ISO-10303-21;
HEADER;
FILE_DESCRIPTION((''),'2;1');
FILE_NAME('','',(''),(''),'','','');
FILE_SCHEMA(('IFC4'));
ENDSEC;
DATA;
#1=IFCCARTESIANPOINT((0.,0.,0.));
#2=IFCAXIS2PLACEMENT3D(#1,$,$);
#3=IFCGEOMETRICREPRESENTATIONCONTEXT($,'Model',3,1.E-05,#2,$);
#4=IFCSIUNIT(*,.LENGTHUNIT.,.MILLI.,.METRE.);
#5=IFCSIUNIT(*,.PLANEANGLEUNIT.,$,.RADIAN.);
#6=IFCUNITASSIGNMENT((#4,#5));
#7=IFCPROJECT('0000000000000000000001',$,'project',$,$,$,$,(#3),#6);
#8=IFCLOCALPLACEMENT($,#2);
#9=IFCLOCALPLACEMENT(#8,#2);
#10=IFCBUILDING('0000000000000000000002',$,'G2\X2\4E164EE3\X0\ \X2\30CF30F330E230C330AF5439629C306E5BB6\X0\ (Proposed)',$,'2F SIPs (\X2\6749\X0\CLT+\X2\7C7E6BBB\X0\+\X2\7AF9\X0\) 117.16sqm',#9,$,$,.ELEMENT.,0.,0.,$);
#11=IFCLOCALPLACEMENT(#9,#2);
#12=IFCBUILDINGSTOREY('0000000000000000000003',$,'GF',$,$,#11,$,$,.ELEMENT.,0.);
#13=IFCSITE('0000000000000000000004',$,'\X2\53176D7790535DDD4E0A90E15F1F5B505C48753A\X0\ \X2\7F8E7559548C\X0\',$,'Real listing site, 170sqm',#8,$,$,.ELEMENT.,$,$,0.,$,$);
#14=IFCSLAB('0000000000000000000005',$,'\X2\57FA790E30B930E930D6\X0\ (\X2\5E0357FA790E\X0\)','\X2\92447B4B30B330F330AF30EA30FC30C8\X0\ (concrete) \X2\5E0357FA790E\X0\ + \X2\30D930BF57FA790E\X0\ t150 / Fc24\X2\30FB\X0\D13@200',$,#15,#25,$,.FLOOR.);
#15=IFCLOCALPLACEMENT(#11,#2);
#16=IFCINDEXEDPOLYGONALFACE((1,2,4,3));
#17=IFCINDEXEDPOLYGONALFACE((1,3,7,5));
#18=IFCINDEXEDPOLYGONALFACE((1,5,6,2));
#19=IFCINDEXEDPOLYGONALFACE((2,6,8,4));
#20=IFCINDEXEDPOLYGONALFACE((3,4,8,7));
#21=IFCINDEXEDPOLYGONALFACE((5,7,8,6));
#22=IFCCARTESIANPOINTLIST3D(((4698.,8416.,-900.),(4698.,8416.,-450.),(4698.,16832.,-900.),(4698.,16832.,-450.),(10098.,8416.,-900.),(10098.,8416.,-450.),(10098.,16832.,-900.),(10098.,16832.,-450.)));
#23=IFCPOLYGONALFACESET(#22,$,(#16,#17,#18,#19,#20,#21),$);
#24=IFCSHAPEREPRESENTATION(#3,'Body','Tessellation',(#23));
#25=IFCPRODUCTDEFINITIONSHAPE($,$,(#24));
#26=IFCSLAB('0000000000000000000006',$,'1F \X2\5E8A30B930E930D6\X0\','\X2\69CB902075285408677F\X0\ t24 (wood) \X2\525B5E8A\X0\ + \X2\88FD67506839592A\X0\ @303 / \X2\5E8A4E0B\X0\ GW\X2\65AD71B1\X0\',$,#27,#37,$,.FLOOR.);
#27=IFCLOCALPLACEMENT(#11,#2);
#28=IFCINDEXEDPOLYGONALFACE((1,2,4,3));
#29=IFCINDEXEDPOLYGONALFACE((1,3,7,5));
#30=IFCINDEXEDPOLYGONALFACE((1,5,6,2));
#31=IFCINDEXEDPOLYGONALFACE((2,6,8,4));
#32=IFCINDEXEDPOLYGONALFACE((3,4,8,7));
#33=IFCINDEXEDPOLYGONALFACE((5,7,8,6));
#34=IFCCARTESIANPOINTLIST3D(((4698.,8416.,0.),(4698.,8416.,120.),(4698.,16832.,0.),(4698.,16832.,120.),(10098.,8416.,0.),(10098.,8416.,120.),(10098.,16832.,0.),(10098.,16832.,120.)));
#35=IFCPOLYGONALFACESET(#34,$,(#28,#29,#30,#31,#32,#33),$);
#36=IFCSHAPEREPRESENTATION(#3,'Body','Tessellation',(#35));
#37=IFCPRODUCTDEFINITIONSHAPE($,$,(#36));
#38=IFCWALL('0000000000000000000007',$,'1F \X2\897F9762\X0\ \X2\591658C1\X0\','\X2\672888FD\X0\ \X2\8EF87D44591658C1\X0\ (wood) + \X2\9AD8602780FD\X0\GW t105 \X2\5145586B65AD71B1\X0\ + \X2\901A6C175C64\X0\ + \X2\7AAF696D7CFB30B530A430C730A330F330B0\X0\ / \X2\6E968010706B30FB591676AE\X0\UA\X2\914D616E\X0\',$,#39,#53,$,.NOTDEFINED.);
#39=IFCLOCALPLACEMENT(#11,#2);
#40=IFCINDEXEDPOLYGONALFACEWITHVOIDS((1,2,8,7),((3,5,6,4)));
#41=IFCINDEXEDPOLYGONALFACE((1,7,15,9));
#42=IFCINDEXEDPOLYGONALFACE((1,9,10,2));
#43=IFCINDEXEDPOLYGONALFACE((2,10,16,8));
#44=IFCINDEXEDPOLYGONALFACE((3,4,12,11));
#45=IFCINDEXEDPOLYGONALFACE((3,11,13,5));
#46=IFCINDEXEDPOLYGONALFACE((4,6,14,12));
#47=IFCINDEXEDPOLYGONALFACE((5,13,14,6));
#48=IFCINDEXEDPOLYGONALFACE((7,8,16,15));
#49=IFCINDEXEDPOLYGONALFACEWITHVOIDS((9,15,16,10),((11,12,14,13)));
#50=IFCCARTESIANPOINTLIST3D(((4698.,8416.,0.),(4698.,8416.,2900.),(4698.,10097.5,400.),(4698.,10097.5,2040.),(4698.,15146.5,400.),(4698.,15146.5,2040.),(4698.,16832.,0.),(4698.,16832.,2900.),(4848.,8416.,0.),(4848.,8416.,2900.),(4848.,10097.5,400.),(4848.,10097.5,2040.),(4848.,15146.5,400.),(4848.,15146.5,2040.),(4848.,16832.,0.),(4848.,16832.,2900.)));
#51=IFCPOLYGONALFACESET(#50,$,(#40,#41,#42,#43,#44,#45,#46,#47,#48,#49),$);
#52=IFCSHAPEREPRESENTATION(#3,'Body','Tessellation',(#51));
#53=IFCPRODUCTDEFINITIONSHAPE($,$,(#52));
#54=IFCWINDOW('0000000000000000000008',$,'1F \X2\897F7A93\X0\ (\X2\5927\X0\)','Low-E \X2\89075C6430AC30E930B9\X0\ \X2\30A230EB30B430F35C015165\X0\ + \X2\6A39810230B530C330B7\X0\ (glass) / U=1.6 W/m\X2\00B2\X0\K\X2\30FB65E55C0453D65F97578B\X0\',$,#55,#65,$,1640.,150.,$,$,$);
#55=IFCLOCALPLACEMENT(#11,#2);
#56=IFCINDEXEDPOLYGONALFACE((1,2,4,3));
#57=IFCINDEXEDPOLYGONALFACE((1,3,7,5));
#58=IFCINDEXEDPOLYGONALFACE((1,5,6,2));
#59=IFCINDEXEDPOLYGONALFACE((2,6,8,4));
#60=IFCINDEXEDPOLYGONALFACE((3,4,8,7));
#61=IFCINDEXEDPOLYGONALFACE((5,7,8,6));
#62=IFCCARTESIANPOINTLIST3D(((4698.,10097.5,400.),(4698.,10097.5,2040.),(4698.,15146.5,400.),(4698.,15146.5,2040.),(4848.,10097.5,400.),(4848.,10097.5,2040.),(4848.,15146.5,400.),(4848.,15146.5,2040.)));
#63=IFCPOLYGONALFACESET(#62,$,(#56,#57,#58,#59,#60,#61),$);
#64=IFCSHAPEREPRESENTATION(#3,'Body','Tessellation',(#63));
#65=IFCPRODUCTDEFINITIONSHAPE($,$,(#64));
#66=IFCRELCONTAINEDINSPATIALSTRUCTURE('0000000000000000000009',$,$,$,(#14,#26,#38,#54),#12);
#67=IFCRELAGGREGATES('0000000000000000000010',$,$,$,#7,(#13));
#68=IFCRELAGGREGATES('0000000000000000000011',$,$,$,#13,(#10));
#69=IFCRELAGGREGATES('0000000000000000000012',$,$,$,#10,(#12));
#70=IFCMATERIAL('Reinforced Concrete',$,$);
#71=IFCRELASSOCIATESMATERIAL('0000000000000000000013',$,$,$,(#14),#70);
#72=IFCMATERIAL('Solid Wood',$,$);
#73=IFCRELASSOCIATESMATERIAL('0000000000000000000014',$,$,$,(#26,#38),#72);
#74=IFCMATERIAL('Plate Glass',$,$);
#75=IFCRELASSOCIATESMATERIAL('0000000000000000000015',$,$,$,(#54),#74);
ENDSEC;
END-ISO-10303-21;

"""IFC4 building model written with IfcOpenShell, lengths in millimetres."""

from ifc_helpers import new_model, si_unit, frame, frame_2d, origin, place, context, project, spatial, rectangle, extrude, material, element, fill, save


model = new_model("IFC4")

# Units and contexts
model_context = context("Model", 3, precision=1e-05, world=origin())
ifc_project = project(units=[si_unit("LENGTHUNIT", "METRE", prefix="MILLI"), si_unit("PLANEANGLEUNIT", "RADIAN")], contexts=[model_context])

# Site, building, storey
site_placement = place(None, origin())
site = spatial("IfcSite", under=ifc_project, at=site_placement, Name="北海道川上郡弟子屈町 美留和", ObjectType="Real listing site, 170sqm", CompositionType="ELEMENT", RefElevation=0.0)
building_placement = place(site_placement, origin())
building = spatial("IfcBuilding", under=site, at=building_placement, Name="G2世代 ハンモック吹抜の家 (Proposed)", ObjectType="2F SIPs (杉CLT+籾殻+竹) 117.16sqm", CompositionType="ELEMENT", ElevationOfRefHeight=0.0, ElevationOfTerrain=0.0)
storey_placement = place(building_placement, origin())
storey = spatial("IfcBuildingStorey", under=building, at=storey_placement, Name="GF", CompositionType="ELEMENT", Elevation=0.0)

# Slabs
ifc_material_1 = material(Name="Reinforced Concrete")
slab_1_placement = place(storey_placement, frame((2349.0, 4208.0, -450.0)))
element("IfcSlab", 1, at=slab_1_placement, inside=storey, material=ifc_material_1, Name="基礎スラブ (布基礎)", Description="鉄筋コンクリート (concrete) 布基礎 + ベタ基礎 t150 / Fc24・D13@200", PredefinedType="FLOOR", context=model_context, shape_type="SweptSolid", body=[
    extrude(rectangle(XDim=5400.0, YDim=8416.0, at=frame_2d((2700.0, 4208.0))), frame((2349.0, 4208.0, -450.0)), (0.0, 0.0, 1.0), 450.0),
])
ifc_material_2 = material(Name="Solid Wood")
slab_2_placement = place(storey_placement, frame((2349.0, 4208.0, 0.0)))
element("IfcSlab", 2, at=slab_2_placement, inside=storey, material=ifc_material_2, Name="1F 床スラブ", Description="構造用合板 t24 (wood) 剛床 + 製材根太 @303 / 床下 GW断熱", PredefinedType="FLOOR", context=model_context, shape_type="SweptSolid", body=[
    extrude(rectangle(XDim=5400.0, YDim=8416.0, at=frame_2d((2700.0, 4208.0))), frame((2349.0, 4208.0, 0.0)), (0.0, 0.0, 1.0), 120.0),
])

# Shared definitions
ifc_material_3 = material(Name="Plate Glass")

# Wall, opening, window
wall_1_placement = place(storey_placement, frame((2349.0, 4208.0, 0.0)))
wall_1 = element("IfcWall", 3, at=wall_1_placement, inside=storey, material=ifc_material_2, Name="1F 西面 外壁", Description="木製 軸組外壁 (wood) + 高性能GW t105 充填断熱 + 通気層 + 窯業系サイディング / 準耐火・外皮UA配慮", PredefinedType="NOTDEFINED", context=model_context, shape_type="SweptSolid", body=[
    extrude(rectangle(XDim=150.0, YDim=8416.0, at=frame_2d((75.0, 4208.0))), frame((2349.0, 4208.0, 0.0)), (0.0, 0.0, 1.0), 2900.0),
])
opening_1_placement = place(storey_placement, frame((2349.0, 5049.0, 200.0)))
opening_1 = element("IfcOpeningElement", 4, at=opening_1_placement, cuts=wall_1, PredefinedType="NOTDEFINED", context=model_context, shape_type="SweptSolid", body=[
    extrude(rectangle(XDim=150.0, YDim=5049.0, at=frame_2d((75.0, 2524.0))), frame((2349.0, 5049.0, 200.0)), (0.0, 0.0, 1.0), 1640.0),
])
window_1_placement = place(storey_placement, frame((2349.0, 5049.0, 200.0)))
window_1 = element("IfcWindow", 5, at=window_1_placement, inside=storey, material=ifc_material_3, Name="1F 西窓 (大)", Description="Low-E 複層ガラス アルゴン封入 + 樹脂サッシ (glass) / U=1.6 W/m²K・日射取得型", OverallHeight=1640.0, OverallWidth=150.0, context=model_context, shape_type="SweptSolid", body=[
    extrude(rectangle(XDim=150.0, YDim=5049.0, at=frame_2d((75.0, 2524.0))), frame((2349.0, 5049.0, 200.0)), (0.0, 0.0, 1.0), 1640.0),
])
fill(opening_1, window_1)

save(model, "model.ifc")
